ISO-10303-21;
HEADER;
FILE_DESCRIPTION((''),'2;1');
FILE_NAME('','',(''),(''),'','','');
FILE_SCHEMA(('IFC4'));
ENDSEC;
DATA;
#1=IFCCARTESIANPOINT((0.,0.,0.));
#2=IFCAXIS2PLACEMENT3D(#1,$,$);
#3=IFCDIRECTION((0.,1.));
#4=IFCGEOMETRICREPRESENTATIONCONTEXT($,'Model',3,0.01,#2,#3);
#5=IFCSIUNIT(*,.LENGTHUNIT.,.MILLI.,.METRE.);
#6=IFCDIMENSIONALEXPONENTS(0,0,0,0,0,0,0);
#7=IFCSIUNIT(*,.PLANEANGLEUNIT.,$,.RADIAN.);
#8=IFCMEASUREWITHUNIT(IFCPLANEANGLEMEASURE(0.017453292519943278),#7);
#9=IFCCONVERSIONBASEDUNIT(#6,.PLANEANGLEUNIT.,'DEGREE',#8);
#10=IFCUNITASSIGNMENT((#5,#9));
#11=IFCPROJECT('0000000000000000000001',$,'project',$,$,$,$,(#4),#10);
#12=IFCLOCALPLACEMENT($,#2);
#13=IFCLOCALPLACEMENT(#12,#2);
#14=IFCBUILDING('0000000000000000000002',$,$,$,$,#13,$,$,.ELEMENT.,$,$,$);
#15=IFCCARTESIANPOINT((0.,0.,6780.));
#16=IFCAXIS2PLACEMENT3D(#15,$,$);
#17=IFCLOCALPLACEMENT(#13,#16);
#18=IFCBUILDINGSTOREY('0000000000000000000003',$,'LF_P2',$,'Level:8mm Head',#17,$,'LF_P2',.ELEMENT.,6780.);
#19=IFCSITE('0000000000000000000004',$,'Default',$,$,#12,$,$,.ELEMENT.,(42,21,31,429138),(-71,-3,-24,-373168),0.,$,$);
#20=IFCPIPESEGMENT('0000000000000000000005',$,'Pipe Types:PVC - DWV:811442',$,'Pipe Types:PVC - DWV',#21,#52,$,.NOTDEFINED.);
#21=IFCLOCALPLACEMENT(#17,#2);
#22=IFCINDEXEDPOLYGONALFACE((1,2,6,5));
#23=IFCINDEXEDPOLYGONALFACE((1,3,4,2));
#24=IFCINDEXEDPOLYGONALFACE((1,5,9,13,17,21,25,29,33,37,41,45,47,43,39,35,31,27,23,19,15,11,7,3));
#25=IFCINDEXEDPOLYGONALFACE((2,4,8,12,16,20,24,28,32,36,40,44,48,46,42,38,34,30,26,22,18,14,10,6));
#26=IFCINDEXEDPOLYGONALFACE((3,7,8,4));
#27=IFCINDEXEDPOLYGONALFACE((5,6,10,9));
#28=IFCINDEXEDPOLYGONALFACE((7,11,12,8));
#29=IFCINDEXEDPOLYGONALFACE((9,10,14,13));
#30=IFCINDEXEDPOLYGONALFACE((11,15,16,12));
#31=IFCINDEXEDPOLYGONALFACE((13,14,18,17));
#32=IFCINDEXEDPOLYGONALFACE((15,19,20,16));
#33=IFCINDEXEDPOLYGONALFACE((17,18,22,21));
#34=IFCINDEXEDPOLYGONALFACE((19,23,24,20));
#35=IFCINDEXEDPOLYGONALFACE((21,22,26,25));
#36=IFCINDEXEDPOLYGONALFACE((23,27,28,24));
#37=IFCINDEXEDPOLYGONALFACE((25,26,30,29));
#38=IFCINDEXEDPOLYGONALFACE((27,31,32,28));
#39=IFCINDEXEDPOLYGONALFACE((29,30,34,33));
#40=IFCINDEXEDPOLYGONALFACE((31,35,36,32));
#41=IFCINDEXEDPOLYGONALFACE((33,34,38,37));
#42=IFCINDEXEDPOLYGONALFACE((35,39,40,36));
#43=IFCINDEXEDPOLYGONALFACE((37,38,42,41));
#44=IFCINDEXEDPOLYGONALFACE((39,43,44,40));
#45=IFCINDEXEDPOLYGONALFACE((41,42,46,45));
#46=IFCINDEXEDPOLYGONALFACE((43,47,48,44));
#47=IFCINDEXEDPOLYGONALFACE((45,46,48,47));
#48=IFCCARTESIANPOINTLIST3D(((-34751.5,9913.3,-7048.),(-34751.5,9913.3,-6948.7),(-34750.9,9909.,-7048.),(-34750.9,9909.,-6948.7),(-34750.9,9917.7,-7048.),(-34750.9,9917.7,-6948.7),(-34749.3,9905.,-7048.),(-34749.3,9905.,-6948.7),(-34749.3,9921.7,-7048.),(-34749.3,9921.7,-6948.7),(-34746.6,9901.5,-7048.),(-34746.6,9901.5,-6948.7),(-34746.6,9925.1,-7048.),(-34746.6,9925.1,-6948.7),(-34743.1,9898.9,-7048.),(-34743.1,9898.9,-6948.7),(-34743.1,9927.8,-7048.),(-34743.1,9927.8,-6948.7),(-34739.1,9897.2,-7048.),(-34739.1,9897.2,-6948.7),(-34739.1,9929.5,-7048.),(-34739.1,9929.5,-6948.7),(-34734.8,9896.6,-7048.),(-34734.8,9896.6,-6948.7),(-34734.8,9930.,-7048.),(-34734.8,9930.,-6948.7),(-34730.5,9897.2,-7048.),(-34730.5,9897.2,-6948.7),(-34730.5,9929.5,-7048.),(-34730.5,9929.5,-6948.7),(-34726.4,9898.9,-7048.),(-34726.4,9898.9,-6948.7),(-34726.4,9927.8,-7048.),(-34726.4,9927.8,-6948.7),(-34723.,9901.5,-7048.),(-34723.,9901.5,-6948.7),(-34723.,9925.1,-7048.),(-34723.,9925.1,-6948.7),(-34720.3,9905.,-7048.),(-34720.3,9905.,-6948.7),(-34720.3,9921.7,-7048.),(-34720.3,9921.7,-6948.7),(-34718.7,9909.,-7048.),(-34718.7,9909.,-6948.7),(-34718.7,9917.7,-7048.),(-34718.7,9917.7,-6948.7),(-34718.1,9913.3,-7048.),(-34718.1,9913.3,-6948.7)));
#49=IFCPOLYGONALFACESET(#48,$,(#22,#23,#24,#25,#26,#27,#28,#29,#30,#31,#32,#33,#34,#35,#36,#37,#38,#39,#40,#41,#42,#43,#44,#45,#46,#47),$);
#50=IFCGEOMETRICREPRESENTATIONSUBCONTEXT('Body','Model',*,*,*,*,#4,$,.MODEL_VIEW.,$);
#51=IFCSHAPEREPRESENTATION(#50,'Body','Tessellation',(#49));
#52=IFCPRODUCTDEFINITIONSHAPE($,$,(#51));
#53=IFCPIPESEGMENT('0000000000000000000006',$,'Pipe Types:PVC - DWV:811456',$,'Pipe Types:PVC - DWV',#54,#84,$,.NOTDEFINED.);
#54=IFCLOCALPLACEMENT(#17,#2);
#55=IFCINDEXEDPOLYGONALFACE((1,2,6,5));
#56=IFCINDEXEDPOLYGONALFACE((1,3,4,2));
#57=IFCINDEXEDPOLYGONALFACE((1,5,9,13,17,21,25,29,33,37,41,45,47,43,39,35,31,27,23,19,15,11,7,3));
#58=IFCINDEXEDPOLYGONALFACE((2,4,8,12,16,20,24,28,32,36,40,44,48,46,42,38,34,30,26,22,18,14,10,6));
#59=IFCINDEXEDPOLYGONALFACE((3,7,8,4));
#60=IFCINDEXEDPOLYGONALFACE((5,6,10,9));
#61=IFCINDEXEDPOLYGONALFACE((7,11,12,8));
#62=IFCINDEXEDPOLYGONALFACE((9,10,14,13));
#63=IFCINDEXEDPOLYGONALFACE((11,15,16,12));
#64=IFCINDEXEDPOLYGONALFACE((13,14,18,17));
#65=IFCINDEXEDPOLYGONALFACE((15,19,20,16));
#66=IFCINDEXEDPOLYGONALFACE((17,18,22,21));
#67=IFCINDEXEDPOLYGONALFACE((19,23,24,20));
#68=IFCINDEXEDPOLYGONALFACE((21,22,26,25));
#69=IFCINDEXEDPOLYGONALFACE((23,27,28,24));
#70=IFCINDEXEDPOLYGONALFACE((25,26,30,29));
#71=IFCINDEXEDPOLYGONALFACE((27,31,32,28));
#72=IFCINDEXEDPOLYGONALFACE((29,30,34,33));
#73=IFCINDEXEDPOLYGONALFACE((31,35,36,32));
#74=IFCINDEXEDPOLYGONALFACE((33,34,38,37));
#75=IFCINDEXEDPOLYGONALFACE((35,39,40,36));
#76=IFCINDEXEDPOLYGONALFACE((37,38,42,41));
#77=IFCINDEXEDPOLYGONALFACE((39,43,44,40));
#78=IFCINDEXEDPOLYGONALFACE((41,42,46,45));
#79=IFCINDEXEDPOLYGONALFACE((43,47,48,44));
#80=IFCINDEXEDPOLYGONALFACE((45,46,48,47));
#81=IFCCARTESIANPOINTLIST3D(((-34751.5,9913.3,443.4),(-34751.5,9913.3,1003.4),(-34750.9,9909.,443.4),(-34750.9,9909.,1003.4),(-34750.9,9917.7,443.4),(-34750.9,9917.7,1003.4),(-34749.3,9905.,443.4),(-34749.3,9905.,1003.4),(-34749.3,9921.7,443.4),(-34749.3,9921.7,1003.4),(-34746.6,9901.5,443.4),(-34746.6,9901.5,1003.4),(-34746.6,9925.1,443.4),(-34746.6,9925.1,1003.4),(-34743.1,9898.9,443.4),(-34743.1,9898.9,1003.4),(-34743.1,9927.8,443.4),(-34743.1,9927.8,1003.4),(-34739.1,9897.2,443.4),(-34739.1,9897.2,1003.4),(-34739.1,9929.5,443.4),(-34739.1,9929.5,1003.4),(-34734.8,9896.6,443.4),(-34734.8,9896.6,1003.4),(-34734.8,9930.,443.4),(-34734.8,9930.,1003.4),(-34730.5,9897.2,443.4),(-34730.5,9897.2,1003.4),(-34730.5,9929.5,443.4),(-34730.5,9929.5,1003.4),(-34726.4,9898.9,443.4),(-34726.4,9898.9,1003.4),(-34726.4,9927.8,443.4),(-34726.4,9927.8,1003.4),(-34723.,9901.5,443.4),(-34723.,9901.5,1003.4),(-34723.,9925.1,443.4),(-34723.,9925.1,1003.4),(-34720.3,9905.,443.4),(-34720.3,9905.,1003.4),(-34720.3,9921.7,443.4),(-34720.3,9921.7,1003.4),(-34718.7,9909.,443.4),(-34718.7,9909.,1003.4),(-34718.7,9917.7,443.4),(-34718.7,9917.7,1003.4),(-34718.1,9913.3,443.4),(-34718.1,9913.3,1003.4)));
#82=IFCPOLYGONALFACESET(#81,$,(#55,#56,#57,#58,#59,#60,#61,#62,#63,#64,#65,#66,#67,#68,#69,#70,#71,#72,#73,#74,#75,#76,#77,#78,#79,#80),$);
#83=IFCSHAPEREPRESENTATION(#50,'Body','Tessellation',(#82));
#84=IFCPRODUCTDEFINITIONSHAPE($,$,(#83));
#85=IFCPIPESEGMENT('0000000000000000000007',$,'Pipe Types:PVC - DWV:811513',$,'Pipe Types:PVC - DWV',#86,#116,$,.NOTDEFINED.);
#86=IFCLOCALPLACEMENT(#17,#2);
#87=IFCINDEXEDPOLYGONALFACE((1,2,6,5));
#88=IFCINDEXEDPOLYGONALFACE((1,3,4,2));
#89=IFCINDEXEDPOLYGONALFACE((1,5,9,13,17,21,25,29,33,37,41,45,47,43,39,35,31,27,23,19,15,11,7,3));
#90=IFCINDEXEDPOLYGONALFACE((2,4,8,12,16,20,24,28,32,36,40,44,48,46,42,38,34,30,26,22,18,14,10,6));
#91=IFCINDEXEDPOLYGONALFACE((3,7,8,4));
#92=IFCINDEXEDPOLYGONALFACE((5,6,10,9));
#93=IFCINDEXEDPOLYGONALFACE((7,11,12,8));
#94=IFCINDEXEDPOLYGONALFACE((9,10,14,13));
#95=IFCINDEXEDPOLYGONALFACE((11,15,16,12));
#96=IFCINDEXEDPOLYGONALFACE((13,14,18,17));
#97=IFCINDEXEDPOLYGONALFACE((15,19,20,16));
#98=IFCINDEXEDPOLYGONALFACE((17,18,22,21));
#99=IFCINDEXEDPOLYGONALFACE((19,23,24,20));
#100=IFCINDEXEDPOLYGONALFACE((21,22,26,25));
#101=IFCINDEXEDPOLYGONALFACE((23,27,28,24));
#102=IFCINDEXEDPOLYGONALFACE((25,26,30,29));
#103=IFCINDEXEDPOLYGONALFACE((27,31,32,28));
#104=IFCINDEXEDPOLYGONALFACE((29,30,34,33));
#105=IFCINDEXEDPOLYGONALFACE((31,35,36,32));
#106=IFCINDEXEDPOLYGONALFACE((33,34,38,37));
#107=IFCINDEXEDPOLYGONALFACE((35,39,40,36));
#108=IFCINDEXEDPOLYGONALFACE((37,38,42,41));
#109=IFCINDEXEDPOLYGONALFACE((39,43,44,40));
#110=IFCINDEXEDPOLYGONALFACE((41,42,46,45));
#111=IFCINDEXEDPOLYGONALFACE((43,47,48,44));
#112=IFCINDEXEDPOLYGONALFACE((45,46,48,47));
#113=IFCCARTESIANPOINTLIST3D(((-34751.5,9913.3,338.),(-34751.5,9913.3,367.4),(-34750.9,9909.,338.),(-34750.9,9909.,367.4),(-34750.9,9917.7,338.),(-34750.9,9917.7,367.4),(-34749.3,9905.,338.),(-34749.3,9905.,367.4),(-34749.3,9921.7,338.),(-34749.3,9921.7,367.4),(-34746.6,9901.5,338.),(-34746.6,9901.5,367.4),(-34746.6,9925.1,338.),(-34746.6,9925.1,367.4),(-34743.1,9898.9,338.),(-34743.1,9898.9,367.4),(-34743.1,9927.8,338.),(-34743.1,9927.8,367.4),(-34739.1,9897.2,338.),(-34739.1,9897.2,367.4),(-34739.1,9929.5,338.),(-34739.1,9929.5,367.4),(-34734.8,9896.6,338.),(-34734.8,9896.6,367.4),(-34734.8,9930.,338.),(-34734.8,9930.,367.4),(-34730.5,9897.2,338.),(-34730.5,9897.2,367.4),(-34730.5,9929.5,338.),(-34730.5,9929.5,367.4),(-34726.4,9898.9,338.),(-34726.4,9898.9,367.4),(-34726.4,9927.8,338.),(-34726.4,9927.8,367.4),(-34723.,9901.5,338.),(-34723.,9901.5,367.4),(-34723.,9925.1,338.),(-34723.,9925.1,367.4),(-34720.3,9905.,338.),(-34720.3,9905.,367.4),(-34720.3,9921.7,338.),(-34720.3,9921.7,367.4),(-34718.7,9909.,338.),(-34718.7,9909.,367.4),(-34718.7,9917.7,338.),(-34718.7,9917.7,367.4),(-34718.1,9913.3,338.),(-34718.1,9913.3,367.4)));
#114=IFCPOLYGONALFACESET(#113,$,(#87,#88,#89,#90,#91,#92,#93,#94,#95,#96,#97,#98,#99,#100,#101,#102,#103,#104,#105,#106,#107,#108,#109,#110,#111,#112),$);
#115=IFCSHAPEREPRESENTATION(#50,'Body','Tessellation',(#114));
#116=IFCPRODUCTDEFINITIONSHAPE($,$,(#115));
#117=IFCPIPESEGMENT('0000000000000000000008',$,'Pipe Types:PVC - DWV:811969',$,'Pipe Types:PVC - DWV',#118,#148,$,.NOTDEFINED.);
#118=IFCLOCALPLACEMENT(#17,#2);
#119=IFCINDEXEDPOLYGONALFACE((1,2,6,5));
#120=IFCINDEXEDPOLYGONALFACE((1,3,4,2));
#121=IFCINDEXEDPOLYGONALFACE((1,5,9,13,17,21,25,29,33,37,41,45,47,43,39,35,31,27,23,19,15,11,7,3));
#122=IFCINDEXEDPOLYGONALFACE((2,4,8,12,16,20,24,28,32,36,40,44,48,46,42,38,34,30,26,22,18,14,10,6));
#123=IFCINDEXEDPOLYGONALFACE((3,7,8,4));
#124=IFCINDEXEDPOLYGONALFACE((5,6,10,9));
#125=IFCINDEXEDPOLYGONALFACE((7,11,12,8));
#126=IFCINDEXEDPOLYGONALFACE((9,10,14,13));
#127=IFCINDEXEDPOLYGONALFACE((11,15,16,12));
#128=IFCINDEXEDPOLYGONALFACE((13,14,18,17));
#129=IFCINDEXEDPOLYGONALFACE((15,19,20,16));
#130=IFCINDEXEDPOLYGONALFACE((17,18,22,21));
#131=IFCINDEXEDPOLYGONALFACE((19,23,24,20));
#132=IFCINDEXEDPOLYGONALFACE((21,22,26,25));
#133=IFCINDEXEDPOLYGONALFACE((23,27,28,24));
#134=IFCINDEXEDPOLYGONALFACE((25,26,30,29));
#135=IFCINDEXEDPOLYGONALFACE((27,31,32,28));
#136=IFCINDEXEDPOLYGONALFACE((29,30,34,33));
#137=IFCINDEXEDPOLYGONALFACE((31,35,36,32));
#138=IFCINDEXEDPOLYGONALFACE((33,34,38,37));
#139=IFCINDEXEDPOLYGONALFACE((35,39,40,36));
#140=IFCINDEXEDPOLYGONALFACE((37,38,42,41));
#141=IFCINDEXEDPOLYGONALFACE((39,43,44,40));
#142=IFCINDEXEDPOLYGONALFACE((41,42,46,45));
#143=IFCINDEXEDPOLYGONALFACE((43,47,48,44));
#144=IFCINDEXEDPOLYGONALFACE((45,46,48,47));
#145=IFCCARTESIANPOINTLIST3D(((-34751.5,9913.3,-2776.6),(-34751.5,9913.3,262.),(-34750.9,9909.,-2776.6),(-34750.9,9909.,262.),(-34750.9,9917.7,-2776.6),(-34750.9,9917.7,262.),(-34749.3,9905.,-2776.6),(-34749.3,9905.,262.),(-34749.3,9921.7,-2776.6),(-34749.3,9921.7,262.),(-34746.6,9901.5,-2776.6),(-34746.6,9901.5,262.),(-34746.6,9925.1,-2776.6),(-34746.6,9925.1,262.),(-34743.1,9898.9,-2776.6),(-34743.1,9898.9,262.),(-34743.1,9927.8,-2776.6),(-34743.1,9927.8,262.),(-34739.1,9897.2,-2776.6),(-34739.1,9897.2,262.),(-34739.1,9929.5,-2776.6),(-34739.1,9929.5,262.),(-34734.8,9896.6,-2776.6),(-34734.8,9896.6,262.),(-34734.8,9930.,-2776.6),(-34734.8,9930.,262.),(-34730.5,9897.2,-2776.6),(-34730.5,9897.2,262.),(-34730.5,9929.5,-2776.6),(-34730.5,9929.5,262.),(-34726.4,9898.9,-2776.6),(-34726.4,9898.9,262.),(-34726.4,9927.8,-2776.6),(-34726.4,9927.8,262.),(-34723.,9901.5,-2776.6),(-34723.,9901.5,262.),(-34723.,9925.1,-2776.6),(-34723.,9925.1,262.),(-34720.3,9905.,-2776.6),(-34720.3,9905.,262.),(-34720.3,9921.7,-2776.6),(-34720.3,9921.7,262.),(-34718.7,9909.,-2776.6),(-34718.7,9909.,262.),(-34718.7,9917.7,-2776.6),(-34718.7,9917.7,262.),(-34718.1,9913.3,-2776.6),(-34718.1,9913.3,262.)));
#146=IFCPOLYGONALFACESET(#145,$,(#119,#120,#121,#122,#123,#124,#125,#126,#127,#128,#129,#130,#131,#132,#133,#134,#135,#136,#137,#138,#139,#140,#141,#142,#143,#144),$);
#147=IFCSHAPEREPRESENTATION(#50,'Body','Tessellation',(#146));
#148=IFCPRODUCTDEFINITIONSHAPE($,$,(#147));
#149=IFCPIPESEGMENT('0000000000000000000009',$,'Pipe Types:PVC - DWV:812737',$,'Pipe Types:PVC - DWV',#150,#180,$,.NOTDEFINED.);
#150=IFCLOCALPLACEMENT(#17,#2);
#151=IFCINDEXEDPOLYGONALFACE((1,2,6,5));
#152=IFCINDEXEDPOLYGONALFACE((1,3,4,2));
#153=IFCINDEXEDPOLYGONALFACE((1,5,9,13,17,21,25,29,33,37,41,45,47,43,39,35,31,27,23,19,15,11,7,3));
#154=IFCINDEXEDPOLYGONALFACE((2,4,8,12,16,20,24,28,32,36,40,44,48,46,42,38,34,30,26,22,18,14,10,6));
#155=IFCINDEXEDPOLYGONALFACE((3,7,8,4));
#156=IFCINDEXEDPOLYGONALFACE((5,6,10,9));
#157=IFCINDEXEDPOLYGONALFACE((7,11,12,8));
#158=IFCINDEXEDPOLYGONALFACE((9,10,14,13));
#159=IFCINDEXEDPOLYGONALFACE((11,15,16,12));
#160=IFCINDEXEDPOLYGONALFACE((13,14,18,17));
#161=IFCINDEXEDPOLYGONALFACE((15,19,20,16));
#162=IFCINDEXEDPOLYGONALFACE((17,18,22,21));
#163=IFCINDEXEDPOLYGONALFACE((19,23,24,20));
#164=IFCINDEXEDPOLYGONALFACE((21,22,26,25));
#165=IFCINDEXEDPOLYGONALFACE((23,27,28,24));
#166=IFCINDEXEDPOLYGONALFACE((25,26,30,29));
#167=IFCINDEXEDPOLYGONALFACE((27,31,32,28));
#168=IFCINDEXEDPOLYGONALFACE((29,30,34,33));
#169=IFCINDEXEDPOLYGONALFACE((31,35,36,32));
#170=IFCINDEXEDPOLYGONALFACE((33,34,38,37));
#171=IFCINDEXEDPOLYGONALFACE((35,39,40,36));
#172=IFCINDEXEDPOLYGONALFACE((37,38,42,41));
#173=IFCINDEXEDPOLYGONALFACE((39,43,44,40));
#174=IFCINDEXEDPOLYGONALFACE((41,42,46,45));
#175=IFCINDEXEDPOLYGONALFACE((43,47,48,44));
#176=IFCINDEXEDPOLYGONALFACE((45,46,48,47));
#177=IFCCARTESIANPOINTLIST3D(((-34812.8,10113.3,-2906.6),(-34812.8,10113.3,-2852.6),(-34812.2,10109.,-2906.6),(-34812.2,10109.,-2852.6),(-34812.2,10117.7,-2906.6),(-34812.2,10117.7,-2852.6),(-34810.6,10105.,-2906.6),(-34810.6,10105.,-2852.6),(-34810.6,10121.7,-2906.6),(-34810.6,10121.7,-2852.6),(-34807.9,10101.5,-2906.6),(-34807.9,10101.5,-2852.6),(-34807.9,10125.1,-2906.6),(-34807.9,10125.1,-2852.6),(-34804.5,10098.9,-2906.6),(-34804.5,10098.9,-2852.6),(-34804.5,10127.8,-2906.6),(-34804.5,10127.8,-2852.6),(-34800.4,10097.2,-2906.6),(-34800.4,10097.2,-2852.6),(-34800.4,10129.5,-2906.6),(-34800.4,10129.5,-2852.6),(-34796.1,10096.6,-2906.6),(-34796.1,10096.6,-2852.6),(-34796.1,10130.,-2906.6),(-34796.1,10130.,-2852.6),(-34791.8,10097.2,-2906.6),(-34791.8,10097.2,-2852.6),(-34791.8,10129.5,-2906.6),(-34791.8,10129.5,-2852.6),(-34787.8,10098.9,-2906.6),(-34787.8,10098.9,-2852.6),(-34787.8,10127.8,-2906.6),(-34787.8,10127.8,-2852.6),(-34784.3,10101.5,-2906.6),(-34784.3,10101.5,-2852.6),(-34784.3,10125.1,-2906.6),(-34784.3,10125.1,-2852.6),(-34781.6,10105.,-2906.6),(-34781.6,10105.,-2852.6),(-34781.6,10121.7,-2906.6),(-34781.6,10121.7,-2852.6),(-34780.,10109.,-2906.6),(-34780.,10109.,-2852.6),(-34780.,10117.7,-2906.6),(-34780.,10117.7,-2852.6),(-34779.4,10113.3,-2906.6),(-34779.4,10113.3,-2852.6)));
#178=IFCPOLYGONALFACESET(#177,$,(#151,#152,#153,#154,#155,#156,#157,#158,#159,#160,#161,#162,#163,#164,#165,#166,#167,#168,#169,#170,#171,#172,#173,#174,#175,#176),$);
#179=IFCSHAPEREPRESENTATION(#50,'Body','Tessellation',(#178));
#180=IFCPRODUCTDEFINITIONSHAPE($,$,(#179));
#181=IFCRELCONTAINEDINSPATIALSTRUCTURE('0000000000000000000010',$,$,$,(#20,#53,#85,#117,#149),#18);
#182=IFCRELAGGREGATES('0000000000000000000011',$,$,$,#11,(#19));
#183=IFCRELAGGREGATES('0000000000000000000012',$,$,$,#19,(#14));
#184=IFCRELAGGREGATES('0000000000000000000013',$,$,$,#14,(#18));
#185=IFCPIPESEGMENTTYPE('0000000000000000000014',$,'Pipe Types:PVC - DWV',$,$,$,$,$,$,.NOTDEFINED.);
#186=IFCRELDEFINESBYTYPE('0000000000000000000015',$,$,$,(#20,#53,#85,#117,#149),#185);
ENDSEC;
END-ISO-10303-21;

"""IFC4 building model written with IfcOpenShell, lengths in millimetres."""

from ifc_helpers import new_model, entity, si_unit, converted_unit, direction, frame, origin, place, context, subcontext, project, spatial, arc, indexed_curve, outline, extrude, type_object, element, save


model = new_model("IFC4")

# Units and contexts
model_context = context("Model", 3, precision=0.01, world=origin(), true_north=direction((0.0, 1.0)))
body_context = subcontext(model_context, "Body", "Model", "MODEL_VIEW")
ifc_project = project(units=[si_unit("LENGTHUNIT", "METRE", prefix="MILLI"), converted_unit("PLANEANGLEUNIT", "DEGREE", entity("IfcPlaneAngleMeasure", 0.017453292519943278), si_unit("PLANEANGLEUNIT", "RADIAN"), dimensions=[0, 0, 0, 0, 0, 0, 0])], contexts=[model_context])

# Site, building, storey
site_placement = place(None, origin())
site = spatial("IfcSite", under=ifc_project, at=site_placement, Name="Default", CompositionType="ELEMENT", RefLatitude=(42, 21, 31, 429138), RefLongitude=(-71, -3, -24, -373168), RefElevation=0.0)
building_placement = place(site_placement, origin())
building = spatial("IfcBuilding", under=site, at=building_placement, CompositionType="ELEMENT")
storey_placement = place(building_placement, frame((0.0, 0.0, 6780.0)))
storey = spatial("IfcBuildingStorey", under=building, at=storey_placement, Name="LF_P2", ObjectType="Level:8mm Head", LongName="LF_P2", CompositionType="ELEMENT", Elevation=6780.0)

# Pipe segments
pipe_segment_type_1 = type_object("IfcPipeSegmentType", Name="Pipe Types:PVC - DWV", PredefinedType="NOTDEFINED")
pipe_segment_1_placement = place(storey_placement, origin())
element("IfcPipeSegment", 1, at=pipe_segment_1_placement, inside=storey, type_object=pipe_segment_type_1, Name="Pipe Types:PVC - DWV:811442", ObjectType="Pipe Types:PVC - DWV", PredefinedType="NOTDEFINED", context=body_context, shape_type="SweptSolid", body=[
    extrude(outline(indexed_curve([(16.7, 0.0), (11.8, 11.8), (0.0, 16.7), (-11.8, 11.8), (-16.7, 0.0), (-11.8, -11.8), (0.0, -16.7), (11.8, -11.8)], segments=[arc(1, 2, 3), arc(3, 4, 5), arc(5, 6, 7), arc(7, 8, 1)], self_intersect=False)), frame((-34734.8, 9913.3, -7048.0)), (0.0, 0.0, 1.0), 99.3),
])
pipe_segment_2_placement = place(storey_placement, origin())
element("IfcPipeSegment", 2, at=pipe_segment_2_placement, inside=storey, type_object=pipe_segment_type_1, Name="Pipe Types:PVC - DWV:811456", ObjectType="Pipe Types:PVC - DWV", PredefinedType="NOTDEFINED", context=body_context, shape_type="SweptSolid", body=[
    extrude(outline(indexed_curve([(16.7, 0.0), (11.8, 11.8), (0.0, 16.7), (-11.8, 11.8), (-16.7, 0.0), (-11.8, -11.8), (0.0, -16.7), (11.8, -11.8)], segments=[arc(1, 2, 3), arc(3, 4, 5), arc(5, 6, 7), arc(7, 8, 1)], self_intersect=False)), frame((-34734.8, 9913.3, 443.4)), (0.0, 0.0, 1.0), 560.0),
])
pipe_segment_3_placement = place(storey_placement, origin())
element("IfcPipeSegment", 3, at=pipe_segment_3_placement, inside=storey, type_object=pipe_segment_type_1, Name="Pipe Types:PVC - DWV:811513", ObjectType="Pipe Types:PVC - DWV", PredefinedType="NOTDEFINED", context=body_context, shape_type="SweptSolid", body=[
    extrude(outline(indexed_curve([(16.7, 0.0), (11.8, 11.8), (0.0, 16.7), (-11.8, 11.8), (-16.7, 0.0), (-11.8, -11.8), (0.0, -16.7), (11.8, -11.8)], segments=[arc(1, 2, 3), arc(3, 4, 5), arc(5, 6, 7), arc(7, 8, 1)], self_intersect=False)), frame((-34734.8, 9913.3, 338.0)), (0.0, 0.0, 1.0), 29.4),
])
pipe_segment_4_placement = place(storey_placement, origin())
element("IfcPipeSegment", 4, at=pipe_segment_4_placement, inside=storey, type_object=pipe_segment_type_1, Name="Pipe Types:PVC - DWV:811969", ObjectType="Pipe Types:PVC - DWV", PredefinedType="NOTDEFINED", context=body_context, shape_type="SweptSolid", body=[
    extrude(outline(indexed_curve([(16.7, 0.0), (11.8, 11.8), (0.0, 16.7), (-11.8, 11.8), (-16.7, 0.0), (-11.8, -11.8), (0.0, -16.7), (11.8, -11.8)], segments=[arc(1, 2, 3), arc(3, 4, 5), arc(5, 6, 7), arc(7, 8, 1)], self_intersect=False)), frame((-34734.8, 9913.3, -2776.6)), (0.0, 0.0, 1.0), 3038.6),
])
pipe_segment_5_placement = place(storey_placement, origin())
element("IfcPipeSegment", 5, at=pipe_segment_5_placement, inside=storey, type_object=pipe_segment_type_1, Name="Pipe Types:PVC - DWV:812737", ObjectType="Pipe Types:PVC - DWV", PredefinedType="NOTDEFINED", context=body_context, shape_type="SweptSolid", body=[
    extrude(outline(indexed_curve([(16.7, 0.0), (11.8, 11.8), (0.0, 16.7), (-11.8, 11.8), (-16.7, 0.0), (-11.8, -11.8), (0.0, -16.7), (11.8, -11.8)], segments=[arc(1, 2, 3), arc(3, 4, 5), arc(5, 6, 7), arc(7, 8, 1)], self_intersect=False)), frame((-34796.1, 10113.3, -2906.6)), (0.0, 0.0, 1.0), 54.0),
])

save(model, "model.ifc")
